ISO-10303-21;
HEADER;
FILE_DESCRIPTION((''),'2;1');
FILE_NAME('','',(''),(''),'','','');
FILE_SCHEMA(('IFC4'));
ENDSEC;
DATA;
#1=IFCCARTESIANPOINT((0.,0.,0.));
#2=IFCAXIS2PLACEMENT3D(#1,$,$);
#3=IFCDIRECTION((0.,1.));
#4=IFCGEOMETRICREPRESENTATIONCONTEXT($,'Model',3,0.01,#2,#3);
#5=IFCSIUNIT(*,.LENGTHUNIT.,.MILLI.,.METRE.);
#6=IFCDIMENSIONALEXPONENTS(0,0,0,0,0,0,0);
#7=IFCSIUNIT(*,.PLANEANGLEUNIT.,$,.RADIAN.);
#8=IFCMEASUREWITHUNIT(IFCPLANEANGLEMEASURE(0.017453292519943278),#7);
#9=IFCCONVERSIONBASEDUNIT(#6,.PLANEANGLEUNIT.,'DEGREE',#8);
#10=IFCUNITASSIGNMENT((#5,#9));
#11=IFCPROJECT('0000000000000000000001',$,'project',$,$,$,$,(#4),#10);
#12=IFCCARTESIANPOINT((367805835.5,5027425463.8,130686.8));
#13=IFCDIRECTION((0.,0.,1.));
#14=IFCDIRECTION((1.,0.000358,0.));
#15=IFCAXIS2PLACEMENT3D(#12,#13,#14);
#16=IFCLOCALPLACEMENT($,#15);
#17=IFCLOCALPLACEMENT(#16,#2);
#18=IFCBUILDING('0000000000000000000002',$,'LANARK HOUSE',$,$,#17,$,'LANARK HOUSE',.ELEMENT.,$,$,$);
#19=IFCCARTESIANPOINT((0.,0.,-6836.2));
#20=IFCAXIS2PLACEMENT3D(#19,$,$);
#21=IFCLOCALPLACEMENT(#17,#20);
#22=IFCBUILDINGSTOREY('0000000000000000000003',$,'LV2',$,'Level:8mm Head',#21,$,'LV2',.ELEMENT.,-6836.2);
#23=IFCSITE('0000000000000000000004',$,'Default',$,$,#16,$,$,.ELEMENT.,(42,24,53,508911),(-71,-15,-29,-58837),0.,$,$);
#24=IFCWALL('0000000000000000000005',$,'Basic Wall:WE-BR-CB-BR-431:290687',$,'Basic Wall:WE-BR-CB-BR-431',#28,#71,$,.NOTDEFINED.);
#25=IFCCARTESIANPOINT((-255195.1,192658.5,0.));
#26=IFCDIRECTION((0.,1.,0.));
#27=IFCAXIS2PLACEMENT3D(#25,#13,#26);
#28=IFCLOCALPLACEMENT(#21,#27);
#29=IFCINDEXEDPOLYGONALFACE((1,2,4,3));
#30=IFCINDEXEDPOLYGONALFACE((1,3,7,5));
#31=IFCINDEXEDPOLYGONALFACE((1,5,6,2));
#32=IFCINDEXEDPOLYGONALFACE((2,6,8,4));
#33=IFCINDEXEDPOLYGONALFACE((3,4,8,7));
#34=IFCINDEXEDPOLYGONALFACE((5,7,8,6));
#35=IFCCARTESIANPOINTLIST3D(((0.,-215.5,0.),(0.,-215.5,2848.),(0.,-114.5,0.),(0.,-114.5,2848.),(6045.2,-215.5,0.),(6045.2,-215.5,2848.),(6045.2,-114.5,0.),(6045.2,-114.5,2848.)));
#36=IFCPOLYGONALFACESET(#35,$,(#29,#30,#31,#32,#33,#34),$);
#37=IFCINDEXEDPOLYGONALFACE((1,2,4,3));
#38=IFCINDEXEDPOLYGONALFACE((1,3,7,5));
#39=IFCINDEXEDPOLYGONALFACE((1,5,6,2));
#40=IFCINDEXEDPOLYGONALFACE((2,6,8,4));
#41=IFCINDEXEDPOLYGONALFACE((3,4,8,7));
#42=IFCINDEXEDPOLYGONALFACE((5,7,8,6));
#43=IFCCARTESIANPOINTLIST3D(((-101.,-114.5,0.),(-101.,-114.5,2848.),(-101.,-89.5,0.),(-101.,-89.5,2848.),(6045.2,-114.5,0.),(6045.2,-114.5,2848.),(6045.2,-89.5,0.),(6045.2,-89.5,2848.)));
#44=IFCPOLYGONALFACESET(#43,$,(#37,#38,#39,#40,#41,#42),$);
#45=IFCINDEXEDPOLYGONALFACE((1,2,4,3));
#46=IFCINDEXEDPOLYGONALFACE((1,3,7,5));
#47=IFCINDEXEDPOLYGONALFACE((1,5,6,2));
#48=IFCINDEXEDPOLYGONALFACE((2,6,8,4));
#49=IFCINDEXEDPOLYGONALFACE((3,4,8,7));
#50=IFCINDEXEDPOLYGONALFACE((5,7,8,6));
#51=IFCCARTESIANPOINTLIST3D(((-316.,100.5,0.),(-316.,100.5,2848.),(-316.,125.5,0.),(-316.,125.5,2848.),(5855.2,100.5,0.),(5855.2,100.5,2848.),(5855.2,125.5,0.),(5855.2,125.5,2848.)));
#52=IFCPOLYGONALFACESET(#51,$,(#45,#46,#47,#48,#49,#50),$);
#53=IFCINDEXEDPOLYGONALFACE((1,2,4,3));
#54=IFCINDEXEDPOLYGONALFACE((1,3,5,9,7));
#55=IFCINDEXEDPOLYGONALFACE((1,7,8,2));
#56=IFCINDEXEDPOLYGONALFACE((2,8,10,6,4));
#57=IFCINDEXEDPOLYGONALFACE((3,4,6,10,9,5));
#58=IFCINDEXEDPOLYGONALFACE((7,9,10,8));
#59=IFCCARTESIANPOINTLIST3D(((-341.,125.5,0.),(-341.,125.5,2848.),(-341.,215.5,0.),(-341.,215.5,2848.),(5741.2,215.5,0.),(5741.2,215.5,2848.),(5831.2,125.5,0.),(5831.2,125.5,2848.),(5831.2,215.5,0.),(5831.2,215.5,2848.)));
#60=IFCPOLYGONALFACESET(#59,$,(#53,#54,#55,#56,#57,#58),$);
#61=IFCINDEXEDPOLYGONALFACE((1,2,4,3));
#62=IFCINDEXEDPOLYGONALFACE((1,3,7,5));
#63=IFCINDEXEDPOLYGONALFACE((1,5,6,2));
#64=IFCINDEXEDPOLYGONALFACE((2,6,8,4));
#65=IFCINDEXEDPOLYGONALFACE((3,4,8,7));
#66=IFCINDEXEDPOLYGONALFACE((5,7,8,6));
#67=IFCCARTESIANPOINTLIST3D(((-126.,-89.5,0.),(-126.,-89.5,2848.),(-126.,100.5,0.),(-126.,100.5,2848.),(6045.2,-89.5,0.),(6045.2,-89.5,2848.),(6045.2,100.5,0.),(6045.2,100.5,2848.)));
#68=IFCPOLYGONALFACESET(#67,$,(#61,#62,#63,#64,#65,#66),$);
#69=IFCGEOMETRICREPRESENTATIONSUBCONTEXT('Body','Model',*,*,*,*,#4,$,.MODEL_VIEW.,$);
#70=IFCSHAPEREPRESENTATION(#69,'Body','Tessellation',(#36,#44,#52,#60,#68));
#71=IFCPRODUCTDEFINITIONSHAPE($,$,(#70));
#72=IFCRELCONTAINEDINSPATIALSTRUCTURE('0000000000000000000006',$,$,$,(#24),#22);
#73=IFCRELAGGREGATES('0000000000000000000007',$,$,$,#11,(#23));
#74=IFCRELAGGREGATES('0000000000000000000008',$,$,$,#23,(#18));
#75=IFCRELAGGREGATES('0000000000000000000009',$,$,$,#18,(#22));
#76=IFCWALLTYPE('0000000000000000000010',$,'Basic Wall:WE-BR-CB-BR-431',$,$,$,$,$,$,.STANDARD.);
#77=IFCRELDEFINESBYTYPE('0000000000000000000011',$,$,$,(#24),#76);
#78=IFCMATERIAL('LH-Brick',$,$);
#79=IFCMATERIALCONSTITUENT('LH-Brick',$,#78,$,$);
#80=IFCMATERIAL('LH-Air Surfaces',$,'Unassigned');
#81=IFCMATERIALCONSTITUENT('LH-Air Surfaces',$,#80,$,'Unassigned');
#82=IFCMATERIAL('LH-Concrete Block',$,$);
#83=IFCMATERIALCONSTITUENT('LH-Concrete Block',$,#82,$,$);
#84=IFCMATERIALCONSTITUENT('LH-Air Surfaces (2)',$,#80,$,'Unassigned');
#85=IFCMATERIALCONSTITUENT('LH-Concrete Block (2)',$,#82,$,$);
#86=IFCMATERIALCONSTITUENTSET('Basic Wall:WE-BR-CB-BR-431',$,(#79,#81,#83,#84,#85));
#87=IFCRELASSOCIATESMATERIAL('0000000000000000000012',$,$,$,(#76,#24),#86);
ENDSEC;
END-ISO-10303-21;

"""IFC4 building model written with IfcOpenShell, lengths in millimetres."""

from ifc_helpers import new_model, entity, si_unit, converted_unit, direction, frame, origin, place, context, subcontext, project, spatial, indexed_curve, outline, extrude, material, constituent, constituent_set, type_object, element, save


model = new_model("IFC4")

# Units and contexts
model_context = context("Model", 3, precision=0.01, world=origin(), true_north=direction((0.0, 1.0)))
body_context = subcontext(model_context, "Body", "Model", "MODEL_VIEW")
ifc_project = project(units=[si_unit("LENGTHUNIT", "METRE", prefix="MILLI"), converted_unit("PLANEANGLEUNIT", "DEGREE", entity("IfcPlaneAngleMeasure", 0.017453292519943278), si_unit("PLANEANGLEUNIT", "RADIAN"), dimensions=[0, 0, 0, 0, 0, 0, 0])], contexts=[model_context])

# Site, building, storey
site_placement = place(None, frame((367805835.5, 5027425463.8, 130686.8), z_axis=(0.0, 0.0, 1.0), x_axis=(1.0, 0.000358, 0.0)))
site = spatial("IfcSite", under=ifc_project, at=site_placement, Name="Default", CompositionType="ELEMENT", RefLatitude=(42, 24, 53, 508911), RefLongitude=(-71, -15, -29, -58837), RefElevation=0.0)
building_placement = place(site_placement, origin())
building = spatial("IfcBuilding", under=site, at=building_placement, Name="LANARK HOUSE", LongName="LANARK HOUSE", CompositionType="ELEMENT")
storey_placement = place(building_placement, frame((0.0, 0.0, -6836.2)))
storey = spatial("IfcBuildingStorey", under=building, at=storey_placement, Name="LV2", ObjectType="Level:8mm Head", LongName="LV2", CompositionType="ELEMENT", Elevation=-6836.2)

# Wall
ifc_material_1 = material(Name="LH-Brick")
ifc_material_2 = material(Name="LH-Air Surfaces", Category="Unassigned")
ifc_material_3 = material(Name="LH-Concrete Block")
ifc_constituent_1 = constituent(ifc_material_1, Name="LH-Brick")
ifc_constituent_2 = constituent(ifc_material_2, Name="LH-Air Surfaces", Category="Unassigned")
ifc_constituent_3 = constituent(ifc_material_3, Name="LH-Concrete Block")
ifc_constituent_4 = constituent(ifc_material_2, Name="LH-Air Surfaces (2)", Category="Unassigned")
ifc_constituent_5 = constituent(ifc_material_3, Name="LH-Concrete Block (2)")
ifc_constituent_set_1 = constituent_set(constituents=[ifc_constituent_1, ifc_constituent_2, ifc_constituent_3, ifc_constituent_4, ifc_constituent_5], Name="Basic Wall:WE-BR-CB-BR-431")
wall_type_1 = type_object("IfcWallType", Name="Basic Wall:WE-BR-CB-BR-431", PredefinedType="STANDARD", material=ifc_constituent_set_1)
wall_1_placement = place(storey_placement, frame((-255195.1, 192658.5, 0.0), z_axis=(0.0, 0.0, 1.0), x_axis=(0.0, 1.0, 0.0)))
element("IfcWall", 1, at=wall_1_placement, inside=storey, type_object=wall_type_1, material=ifc_constituent_set_1, Name="Basic Wall:WE-BR-CB-BR-431:290687", ObjectType="Basic Wall:WE-BR-CB-BR-431", PredefinedType="NOTDEFINED", context=body_context, shape_type="SweptSolid", body=[
    extrude(outline(indexed_curve([(-50.5, -3022.6), (50.5, -3022.6), (50.5, 3022.6), (-50.5, 3022.6), (-50.5, -3022.6)], self_intersect=False)), frame((3022.6, -165.0, 0.0), z_axis=(0.0, 0.0, 1.0), x_axis=(0.0, 1.0, 0.0)), (0.0, 0.0, 1.0), 2848.0),
    extrude(outline(indexed_curve([(-3073.1, -12.5), (3073.1, -12.5), (3073.1, 12.5), (-3073.1, 12.5), (-3073.1, -12.5)], self_intersect=False)), frame((2972.1, -102.0, 0.0)), (0.0, 0.0, 1.0), 2848.0),
    extrude(outline(indexed_curve([(-3085.6, -12.5), (3085.6, -12.5), (3085.6, 12.5), (-3085.6, 12.5), (-3085.6, -12.5)], self_intersect=False)), frame((2769.6, 113.0, 0.0)), (0.0, 0.0, 1.0), 2848.0),
    extrude(outline(indexed_curve([(-2396.9, -36.0), (3685.3, -36.0), (3685.3, 54.0), (-2486.9, 54.0), (-2486.9, -36.0), (-2396.9, -36.0)], self_intersect=False)), frame((3344.3, 179.5, 0.0), z_axis=(0.0, 0.0, 1.0), x_axis=(-1.0, 0.0, 0.0)), (0.0, 0.0, 1.0), 2848.0),
    extrude(outline(indexed_curve([(-3085.6, -95.0), (3085.6, -95.0), (3085.6, 95.0), (-3085.6, 95.0), (-3085.6, -95.0)], self_intersect=False)), frame((2959.6, 5.5, 0.0)), (0.0, 0.0, 1.0), 2848.0),
])

save(model, "model.ifc")
